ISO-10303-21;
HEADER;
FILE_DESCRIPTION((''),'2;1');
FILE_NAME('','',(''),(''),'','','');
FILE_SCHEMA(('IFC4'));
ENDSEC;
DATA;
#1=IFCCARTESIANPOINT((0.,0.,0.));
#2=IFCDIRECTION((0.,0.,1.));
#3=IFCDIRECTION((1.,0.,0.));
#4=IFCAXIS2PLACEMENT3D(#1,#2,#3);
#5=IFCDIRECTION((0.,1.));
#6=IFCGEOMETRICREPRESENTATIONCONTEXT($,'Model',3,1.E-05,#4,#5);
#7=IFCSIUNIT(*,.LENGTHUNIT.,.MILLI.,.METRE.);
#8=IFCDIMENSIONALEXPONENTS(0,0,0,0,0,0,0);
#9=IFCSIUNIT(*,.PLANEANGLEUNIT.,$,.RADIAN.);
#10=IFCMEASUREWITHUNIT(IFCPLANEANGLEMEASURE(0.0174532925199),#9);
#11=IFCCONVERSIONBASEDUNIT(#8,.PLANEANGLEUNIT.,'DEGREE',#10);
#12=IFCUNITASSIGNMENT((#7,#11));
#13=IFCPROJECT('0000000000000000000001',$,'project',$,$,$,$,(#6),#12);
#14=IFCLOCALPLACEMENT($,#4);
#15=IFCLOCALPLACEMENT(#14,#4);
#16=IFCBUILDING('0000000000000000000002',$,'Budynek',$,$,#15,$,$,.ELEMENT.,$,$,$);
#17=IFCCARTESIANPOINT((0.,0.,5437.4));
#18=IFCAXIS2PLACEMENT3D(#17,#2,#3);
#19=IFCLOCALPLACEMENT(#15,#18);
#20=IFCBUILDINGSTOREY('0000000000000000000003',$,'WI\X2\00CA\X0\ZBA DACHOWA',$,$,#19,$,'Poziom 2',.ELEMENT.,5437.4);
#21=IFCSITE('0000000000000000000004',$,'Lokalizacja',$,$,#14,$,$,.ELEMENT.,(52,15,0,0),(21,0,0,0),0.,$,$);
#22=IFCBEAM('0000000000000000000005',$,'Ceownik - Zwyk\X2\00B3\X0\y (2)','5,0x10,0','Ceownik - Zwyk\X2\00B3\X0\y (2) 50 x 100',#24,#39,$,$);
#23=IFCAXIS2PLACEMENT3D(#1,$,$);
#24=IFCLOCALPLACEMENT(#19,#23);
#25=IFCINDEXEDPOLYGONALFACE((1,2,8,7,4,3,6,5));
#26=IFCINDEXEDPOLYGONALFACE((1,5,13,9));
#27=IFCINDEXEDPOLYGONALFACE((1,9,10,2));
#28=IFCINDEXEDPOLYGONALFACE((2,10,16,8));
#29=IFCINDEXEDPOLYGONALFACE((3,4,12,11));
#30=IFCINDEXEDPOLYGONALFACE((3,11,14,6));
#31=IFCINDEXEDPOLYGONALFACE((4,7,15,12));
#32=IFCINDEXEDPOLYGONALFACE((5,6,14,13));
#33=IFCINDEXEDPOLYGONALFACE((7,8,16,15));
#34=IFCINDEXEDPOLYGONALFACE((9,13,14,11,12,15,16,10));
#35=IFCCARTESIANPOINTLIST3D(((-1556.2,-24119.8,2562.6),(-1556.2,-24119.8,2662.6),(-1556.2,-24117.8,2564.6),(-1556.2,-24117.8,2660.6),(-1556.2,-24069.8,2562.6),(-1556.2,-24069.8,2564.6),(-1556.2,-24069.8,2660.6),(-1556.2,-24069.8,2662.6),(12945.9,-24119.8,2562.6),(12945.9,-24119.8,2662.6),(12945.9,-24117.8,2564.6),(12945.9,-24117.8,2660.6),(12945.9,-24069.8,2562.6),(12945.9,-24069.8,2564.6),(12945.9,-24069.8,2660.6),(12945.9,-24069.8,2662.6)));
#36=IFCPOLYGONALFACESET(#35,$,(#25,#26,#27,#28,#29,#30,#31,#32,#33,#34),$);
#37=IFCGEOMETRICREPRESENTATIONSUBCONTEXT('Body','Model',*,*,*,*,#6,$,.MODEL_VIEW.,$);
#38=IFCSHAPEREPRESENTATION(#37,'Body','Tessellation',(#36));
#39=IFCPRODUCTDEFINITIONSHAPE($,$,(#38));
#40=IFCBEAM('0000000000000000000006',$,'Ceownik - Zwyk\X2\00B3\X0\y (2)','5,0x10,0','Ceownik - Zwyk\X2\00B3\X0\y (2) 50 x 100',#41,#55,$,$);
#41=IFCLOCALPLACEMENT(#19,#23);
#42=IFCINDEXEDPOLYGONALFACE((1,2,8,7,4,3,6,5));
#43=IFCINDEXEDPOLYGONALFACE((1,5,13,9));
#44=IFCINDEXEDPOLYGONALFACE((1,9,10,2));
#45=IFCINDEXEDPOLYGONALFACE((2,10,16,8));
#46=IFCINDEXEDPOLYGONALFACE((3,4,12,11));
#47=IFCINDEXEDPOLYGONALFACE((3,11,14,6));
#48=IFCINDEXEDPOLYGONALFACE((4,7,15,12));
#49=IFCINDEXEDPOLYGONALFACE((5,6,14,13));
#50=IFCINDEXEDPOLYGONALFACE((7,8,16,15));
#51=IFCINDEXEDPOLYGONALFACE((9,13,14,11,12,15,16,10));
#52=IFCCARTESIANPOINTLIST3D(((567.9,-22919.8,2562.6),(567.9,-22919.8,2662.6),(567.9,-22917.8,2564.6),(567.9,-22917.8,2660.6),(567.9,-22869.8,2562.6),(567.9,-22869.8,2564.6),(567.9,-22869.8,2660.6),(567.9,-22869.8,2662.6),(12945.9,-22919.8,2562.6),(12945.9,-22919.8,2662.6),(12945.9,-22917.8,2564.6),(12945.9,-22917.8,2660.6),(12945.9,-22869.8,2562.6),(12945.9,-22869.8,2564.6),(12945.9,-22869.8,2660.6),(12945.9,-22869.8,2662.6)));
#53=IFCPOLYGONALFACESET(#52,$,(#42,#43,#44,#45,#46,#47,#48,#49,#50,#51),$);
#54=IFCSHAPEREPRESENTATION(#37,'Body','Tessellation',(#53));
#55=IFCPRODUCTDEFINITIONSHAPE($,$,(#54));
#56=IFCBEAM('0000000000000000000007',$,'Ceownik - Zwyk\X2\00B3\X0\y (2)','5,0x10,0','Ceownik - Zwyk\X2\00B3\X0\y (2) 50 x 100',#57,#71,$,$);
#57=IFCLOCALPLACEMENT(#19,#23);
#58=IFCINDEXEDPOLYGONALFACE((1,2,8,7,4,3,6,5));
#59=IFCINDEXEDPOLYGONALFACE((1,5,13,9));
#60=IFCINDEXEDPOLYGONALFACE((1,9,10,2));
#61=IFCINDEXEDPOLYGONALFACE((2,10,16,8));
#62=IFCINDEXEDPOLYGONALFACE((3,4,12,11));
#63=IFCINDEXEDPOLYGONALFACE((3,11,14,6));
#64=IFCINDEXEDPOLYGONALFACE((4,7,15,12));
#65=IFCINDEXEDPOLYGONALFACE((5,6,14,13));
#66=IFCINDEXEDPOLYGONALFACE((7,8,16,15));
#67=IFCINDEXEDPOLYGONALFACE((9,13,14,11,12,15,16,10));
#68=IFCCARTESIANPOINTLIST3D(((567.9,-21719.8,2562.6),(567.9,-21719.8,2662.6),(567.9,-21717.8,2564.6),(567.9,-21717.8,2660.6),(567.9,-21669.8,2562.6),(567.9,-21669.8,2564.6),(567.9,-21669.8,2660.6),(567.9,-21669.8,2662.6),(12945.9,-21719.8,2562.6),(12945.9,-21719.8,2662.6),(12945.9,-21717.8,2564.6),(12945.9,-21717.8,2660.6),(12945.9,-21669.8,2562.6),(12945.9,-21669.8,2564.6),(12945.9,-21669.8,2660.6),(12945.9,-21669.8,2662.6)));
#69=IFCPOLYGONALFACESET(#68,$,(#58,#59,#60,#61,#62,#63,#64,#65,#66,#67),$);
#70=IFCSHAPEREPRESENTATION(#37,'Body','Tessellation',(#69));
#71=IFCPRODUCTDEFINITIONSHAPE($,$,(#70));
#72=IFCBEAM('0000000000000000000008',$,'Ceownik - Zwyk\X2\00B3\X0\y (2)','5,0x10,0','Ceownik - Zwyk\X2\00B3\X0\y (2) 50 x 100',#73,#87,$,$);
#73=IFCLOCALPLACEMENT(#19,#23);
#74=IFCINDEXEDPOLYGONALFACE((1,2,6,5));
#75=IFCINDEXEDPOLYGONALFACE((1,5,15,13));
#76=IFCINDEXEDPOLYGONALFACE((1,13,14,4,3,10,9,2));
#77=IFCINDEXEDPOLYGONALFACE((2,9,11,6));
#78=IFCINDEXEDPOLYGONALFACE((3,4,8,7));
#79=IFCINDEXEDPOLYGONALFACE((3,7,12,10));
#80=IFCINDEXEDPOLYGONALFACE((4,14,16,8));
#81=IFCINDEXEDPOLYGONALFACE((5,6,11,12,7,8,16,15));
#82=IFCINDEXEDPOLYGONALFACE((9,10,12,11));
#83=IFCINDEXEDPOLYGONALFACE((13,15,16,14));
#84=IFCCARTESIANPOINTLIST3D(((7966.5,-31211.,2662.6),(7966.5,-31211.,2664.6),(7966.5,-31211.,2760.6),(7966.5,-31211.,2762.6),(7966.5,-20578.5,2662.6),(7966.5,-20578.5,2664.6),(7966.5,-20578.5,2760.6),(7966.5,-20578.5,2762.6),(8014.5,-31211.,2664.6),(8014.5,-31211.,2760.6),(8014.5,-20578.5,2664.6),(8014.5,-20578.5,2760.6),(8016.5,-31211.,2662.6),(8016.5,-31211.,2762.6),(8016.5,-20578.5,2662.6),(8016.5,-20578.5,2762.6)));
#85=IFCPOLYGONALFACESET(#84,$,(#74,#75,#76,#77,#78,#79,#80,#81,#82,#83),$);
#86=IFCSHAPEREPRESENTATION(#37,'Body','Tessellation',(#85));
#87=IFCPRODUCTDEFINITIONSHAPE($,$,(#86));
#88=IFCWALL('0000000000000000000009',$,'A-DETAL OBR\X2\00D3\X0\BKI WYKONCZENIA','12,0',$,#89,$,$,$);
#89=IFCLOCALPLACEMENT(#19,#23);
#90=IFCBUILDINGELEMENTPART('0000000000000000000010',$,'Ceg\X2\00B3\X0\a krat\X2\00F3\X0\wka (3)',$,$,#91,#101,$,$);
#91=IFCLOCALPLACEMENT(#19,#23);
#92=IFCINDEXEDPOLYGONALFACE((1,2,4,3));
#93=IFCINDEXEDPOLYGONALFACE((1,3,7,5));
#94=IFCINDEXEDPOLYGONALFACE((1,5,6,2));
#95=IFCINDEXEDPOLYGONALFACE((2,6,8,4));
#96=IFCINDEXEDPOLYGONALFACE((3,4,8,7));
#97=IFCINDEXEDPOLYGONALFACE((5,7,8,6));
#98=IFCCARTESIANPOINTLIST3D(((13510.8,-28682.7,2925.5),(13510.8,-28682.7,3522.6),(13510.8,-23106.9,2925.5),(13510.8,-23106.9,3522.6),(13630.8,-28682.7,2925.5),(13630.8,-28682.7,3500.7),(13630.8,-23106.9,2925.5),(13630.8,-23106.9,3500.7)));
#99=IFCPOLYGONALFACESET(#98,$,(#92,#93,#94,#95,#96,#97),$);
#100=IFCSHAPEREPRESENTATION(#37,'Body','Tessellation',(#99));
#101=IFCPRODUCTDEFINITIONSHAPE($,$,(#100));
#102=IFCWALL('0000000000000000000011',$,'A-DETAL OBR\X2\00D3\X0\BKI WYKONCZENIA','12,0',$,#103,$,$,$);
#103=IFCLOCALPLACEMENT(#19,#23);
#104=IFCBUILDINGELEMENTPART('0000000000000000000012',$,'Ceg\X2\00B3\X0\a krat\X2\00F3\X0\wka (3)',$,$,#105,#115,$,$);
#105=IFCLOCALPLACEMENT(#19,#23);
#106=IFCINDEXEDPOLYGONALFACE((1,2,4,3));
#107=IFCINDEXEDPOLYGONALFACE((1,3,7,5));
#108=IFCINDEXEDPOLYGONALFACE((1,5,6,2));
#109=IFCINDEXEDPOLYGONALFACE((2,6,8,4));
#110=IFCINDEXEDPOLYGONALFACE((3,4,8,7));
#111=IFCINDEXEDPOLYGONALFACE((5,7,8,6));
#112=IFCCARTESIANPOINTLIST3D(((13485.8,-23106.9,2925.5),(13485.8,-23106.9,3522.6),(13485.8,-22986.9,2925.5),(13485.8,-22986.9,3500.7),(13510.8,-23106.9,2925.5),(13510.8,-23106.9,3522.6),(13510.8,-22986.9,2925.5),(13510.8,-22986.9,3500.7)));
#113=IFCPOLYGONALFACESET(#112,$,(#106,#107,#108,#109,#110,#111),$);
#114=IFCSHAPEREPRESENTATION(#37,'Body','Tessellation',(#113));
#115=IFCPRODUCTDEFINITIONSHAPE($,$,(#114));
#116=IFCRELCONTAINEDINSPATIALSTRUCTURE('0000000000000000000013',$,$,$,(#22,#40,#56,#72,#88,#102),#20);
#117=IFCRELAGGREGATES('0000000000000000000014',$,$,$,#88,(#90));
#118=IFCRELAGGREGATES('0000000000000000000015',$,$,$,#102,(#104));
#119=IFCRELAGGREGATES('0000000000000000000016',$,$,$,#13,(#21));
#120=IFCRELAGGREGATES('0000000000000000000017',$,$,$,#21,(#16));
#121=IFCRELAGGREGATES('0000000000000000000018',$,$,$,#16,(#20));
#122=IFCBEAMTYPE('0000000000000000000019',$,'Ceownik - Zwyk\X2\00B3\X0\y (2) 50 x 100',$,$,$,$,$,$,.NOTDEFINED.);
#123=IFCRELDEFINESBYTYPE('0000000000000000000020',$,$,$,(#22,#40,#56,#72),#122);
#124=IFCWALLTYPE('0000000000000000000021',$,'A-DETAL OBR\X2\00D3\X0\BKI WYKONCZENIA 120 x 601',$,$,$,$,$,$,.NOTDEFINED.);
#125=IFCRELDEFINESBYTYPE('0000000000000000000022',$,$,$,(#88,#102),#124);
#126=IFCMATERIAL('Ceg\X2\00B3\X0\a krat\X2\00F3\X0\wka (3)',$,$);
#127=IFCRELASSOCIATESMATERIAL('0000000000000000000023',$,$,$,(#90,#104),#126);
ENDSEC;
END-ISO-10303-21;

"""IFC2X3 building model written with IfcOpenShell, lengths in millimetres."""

from ifc_helpers import new_model, entity, si_unit, converted_unit, direction, frame, origin_with_axes, place, context, subcontext, project, spatial, polyline, outline, extrude, material, type_object, element, aggregate, save


model = new_model("IFC2X3")

# Units and contexts
model_context = context("Model", 3, precision=1e-05, world=origin_with_axes(), true_north=direction((0.0, 1.0)))
body_context = subcontext(model_context, "Body", "Model", "MODEL_VIEW")
ifc_project = project(units=[si_unit("LENGTHUNIT", "METRE", prefix="MILLI"), converted_unit("PLANEANGLEUNIT", "DEGREE", entity("IfcPlaneAngleMeasure", 0.0174532925199), si_unit("PLANEANGLEUNIT", "RADIAN"), dimensions=[0, 0, 0, 0, 0, 0, 0])], contexts=[model_context])

# Site, building, storey
site_placement = place(None, origin_with_axes())
site = spatial("IfcSite", under=ifc_project, at=site_placement, Name="Lokalizacja", CompositionType="ELEMENT", RefLatitude=(52, 15, 0, 0), RefLongitude=(21, 0, 0, 0), RefElevation=0.0)
building_placement = place(site_placement, origin_with_axes())
building = spatial("IfcBuilding", under=site, at=building_placement, Name="Budynek", CompositionType="ELEMENT")
storey_placement = place(building_placement, frame((0.0, 0.0, 5437.4), z_axis=(0.0, 0.0, 1.0), x_axis=(1.0, 0.0, 0.0)))
storey = spatial("IfcBuildingStorey", under=building, at=storey_placement, Name="WIÊZBA DACHOWA", LongName="Poziom 2", CompositionType="ELEMENT", Elevation=5437.4)

# Beams
beam_type_1 = type_object("IfcBeamType", Name="Ceownik - Zwyk³y (2) 50 x 100", PredefinedType="NOTDEFINED")
beam_1_placement = place(storey_placement, frame((-1556.2, -24094.8, 2662.6), z_axis=(0.0, 0.0, 1.0), x_axis=(0.0, -1.0, 0.0)))
element("IfcBeam", 1, at=beam_1_placement, inside=storey, type_object=beam_type_1, Name="Ceownik - Zwyk³y (2)", Description="5,0x10,0", ObjectType="Ceownik - Zwyk³y (2) 50 x 100", context=body_context, shape_type="SweptSolid", body=[
    extrude(outline(polyline([(25.0, -100.0), (25.0, -98.0), (-23.0, -98.0), (-23.0, -2.0), (25.0, -2.0), (25.0, 0.0), (-25.0, 0.0), (-25.0, -100.0), (25.0, -100.0)])), frame((0.0, 14502.1, 0.0), z_axis=(0.0, 1.0, 0.0), x_axis=(-1.0, 0.0, 0.0)), (0.0, 0.0, -1.0), 14502.1),
])
beam_2_placement = place(storey_placement, frame((567.9, -22894.8, 2662.6), z_axis=(0.0, 0.0, 1.0), x_axis=(0.0, -1.0, 0.0)))
element("IfcBeam", 2, at=beam_2_placement, inside=storey, type_object=beam_type_1, Name="Ceownik - Zwyk³y (2)", Description="5,0x10,0", ObjectType="Ceownik - Zwyk³y (2) 50 x 100", context=body_context, shape_type="SweptSolid", body=[
    extrude(outline(polyline([(25.0, -100.0), (25.0, -98.0), (-23.0, -98.0), (-23.0, -2.0), (25.0, -2.0), (25.0, 0.0), (-25.0, 0.0), (-25.0, -100.0), (25.0, -100.0)])), frame((0.0, 12378.0, 0.0), z_axis=(0.0, 1.0, 0.0), x_axis=(-1.0, 0.0, 0.0)), (0.0, 0.0, -1.0), 12378.0),
])
beam_3_placement = place(storey_placement, frame((567.9, -21694.8, 2662.6), z_axis=(0.0, 0.0, 1.0), x_axis=(0.0, -1.0, 0.0)))
element("IfcBeam", 3, at=beam_3_placement, inside=storey, type_object=beam_type_1, Name="Ceownik - Zwyk³y (2)", Description="5,0x10,0", ObjectType="Ceownik - Zwyk³y (2) 50 x 100", context=body_context, shape_type="SweptSolid", body=[
    extrude(outline(polyline([(25.0, -100.0), (25.0, -98.0), (-23.0, -98.0), (-23.0, -2.0), (25.0, -2.0), (25.0, 0.0), (-25.0, 0.0), (-25.0, -100.0), (25.0, -100.0)])), frame((0.0, 12378.0, 0.0), z_axis=(0.0, 1.0, 0.0), x_axis=(-1.0, 0.0, 0.0)), (0.0, 0.0, -1.0), 12378.0),
])
beam_4_placement = place(storey_placement, frame((7991.5, -20578.5, 2762.6), z_axis=(0.0, 0.0, 1.0), x_axis=(-1.0, 0.0, 0.0)))
element("IfcBeam", 4, at=beam_4_placement, inside=storey, type_object=beam_type_1, Name="Ceownik - Zwyk³y (2)", Description="5,0x10,0", ObjectType="Ceownik - Zwyk³y (2) 50 x 100", context=body_context, shape_type="SweptSolid", body=[
    extrude(outline(polyline([(25.0, -100.0), (25.0, -98.0), (-23.0, -98.0), (-23.0, -2.0), (25.0, -2.0), (25.0, 0.0), (-25.0, 0.0), (-25.0, -100.0), (25.0, -100.0)])), frame((0.0, 10632.5, 0.0), z_axis=(0.0, -1.0, 0.0), x_axis=(1.0, 0.0, 0.0)), (0.0, 0.0, 1.0), 10632.5),
])

# Shared definitions
ifc_material_1 = material(Name="Ceg³a kratówka (3)")

# Walls, building element parts
wall_type = type_object("IfcWallType", Name="A-DETAL OBRÓBKI WYKONCZENIA 120 x 601", PredefinedType="NOTDEFINED")
wall_1_placement = place(storey_placement, frame((13510.8, -23106.9, 2925.5), z_axis=(0.0, 0.0, 1.0), x_axis=(0.0, -1.0, 0.0)))
wall_1 = element("IfcWall", 5, at=wall_1_placement, inside=storey, type_object=wall_type, Name="A-DETAL OBRÓBKI WYKONCZENIA", Description="12,0")
building_element_part_1_placement = place(wall_1_placement, origin_with_axes())
building_element_part_1 = element("IfcBuildingElementPart", 6, at=building_element_part_1_placement, material=ifc_material_1, Name="Ceg³a kratówka (3)", context=body_context, shape_type="SweptSolid", body=[
    extrude(outline(polyline([(0.0, 0.0), (0.0, 597.1), (-120.0, 575.2), (-120.0, 0.0), (0.0, 0.0)])), frame((0.0, 0.0, 0.0), z_axis=(-1.0, 0.0, 0.0), x_axis=(0.0, -1.0, 0.0)), (0.0, 0.0, -1.0), 5575.8),
])
aggregate(wall_1, [building_element_part_1])
wall_2_placement = place(storey_placement, frame((13485.8, -23106.9, 2925.5), z_axis=(0.0, 0.0, 1.0), x_axis=(1.0, 0.0, 0.0)))
wall_2 = element("IfcWall", 7, at=wall_2_placement, inside=storey, type_object=wall_type, Name="A-DETAL OBRÓBKI WYKONCZENIA", Description="12,0")
building_element_part_2_placement = place(wall_2_placement, origin_with_axes())
building_element_part_2 = element("IfcBuildingElementPart", 8, at=building_element_part_2_placement, material=ifc_material_1, Name="Ceg³a kratówka (3)", context=body_context, shape_type="SweptSolid", body=[
    extrude(outline(polyline([(0.0, 0.0), (0.0, 597.1), (-120.0, 575.2), (-120.0, 0.0), (0.0, 0.0)])), frame((0.0, 0.0, 0.0), z_axis=(-1.0, 0.0, 0.0), x_axis=(0.0, -1.0, 0.0)), (0.0, 0.0, -1.0), 24.9),
])
aggregate(wall_2, [building_element_part_2])

save(model, "model.ifc")
